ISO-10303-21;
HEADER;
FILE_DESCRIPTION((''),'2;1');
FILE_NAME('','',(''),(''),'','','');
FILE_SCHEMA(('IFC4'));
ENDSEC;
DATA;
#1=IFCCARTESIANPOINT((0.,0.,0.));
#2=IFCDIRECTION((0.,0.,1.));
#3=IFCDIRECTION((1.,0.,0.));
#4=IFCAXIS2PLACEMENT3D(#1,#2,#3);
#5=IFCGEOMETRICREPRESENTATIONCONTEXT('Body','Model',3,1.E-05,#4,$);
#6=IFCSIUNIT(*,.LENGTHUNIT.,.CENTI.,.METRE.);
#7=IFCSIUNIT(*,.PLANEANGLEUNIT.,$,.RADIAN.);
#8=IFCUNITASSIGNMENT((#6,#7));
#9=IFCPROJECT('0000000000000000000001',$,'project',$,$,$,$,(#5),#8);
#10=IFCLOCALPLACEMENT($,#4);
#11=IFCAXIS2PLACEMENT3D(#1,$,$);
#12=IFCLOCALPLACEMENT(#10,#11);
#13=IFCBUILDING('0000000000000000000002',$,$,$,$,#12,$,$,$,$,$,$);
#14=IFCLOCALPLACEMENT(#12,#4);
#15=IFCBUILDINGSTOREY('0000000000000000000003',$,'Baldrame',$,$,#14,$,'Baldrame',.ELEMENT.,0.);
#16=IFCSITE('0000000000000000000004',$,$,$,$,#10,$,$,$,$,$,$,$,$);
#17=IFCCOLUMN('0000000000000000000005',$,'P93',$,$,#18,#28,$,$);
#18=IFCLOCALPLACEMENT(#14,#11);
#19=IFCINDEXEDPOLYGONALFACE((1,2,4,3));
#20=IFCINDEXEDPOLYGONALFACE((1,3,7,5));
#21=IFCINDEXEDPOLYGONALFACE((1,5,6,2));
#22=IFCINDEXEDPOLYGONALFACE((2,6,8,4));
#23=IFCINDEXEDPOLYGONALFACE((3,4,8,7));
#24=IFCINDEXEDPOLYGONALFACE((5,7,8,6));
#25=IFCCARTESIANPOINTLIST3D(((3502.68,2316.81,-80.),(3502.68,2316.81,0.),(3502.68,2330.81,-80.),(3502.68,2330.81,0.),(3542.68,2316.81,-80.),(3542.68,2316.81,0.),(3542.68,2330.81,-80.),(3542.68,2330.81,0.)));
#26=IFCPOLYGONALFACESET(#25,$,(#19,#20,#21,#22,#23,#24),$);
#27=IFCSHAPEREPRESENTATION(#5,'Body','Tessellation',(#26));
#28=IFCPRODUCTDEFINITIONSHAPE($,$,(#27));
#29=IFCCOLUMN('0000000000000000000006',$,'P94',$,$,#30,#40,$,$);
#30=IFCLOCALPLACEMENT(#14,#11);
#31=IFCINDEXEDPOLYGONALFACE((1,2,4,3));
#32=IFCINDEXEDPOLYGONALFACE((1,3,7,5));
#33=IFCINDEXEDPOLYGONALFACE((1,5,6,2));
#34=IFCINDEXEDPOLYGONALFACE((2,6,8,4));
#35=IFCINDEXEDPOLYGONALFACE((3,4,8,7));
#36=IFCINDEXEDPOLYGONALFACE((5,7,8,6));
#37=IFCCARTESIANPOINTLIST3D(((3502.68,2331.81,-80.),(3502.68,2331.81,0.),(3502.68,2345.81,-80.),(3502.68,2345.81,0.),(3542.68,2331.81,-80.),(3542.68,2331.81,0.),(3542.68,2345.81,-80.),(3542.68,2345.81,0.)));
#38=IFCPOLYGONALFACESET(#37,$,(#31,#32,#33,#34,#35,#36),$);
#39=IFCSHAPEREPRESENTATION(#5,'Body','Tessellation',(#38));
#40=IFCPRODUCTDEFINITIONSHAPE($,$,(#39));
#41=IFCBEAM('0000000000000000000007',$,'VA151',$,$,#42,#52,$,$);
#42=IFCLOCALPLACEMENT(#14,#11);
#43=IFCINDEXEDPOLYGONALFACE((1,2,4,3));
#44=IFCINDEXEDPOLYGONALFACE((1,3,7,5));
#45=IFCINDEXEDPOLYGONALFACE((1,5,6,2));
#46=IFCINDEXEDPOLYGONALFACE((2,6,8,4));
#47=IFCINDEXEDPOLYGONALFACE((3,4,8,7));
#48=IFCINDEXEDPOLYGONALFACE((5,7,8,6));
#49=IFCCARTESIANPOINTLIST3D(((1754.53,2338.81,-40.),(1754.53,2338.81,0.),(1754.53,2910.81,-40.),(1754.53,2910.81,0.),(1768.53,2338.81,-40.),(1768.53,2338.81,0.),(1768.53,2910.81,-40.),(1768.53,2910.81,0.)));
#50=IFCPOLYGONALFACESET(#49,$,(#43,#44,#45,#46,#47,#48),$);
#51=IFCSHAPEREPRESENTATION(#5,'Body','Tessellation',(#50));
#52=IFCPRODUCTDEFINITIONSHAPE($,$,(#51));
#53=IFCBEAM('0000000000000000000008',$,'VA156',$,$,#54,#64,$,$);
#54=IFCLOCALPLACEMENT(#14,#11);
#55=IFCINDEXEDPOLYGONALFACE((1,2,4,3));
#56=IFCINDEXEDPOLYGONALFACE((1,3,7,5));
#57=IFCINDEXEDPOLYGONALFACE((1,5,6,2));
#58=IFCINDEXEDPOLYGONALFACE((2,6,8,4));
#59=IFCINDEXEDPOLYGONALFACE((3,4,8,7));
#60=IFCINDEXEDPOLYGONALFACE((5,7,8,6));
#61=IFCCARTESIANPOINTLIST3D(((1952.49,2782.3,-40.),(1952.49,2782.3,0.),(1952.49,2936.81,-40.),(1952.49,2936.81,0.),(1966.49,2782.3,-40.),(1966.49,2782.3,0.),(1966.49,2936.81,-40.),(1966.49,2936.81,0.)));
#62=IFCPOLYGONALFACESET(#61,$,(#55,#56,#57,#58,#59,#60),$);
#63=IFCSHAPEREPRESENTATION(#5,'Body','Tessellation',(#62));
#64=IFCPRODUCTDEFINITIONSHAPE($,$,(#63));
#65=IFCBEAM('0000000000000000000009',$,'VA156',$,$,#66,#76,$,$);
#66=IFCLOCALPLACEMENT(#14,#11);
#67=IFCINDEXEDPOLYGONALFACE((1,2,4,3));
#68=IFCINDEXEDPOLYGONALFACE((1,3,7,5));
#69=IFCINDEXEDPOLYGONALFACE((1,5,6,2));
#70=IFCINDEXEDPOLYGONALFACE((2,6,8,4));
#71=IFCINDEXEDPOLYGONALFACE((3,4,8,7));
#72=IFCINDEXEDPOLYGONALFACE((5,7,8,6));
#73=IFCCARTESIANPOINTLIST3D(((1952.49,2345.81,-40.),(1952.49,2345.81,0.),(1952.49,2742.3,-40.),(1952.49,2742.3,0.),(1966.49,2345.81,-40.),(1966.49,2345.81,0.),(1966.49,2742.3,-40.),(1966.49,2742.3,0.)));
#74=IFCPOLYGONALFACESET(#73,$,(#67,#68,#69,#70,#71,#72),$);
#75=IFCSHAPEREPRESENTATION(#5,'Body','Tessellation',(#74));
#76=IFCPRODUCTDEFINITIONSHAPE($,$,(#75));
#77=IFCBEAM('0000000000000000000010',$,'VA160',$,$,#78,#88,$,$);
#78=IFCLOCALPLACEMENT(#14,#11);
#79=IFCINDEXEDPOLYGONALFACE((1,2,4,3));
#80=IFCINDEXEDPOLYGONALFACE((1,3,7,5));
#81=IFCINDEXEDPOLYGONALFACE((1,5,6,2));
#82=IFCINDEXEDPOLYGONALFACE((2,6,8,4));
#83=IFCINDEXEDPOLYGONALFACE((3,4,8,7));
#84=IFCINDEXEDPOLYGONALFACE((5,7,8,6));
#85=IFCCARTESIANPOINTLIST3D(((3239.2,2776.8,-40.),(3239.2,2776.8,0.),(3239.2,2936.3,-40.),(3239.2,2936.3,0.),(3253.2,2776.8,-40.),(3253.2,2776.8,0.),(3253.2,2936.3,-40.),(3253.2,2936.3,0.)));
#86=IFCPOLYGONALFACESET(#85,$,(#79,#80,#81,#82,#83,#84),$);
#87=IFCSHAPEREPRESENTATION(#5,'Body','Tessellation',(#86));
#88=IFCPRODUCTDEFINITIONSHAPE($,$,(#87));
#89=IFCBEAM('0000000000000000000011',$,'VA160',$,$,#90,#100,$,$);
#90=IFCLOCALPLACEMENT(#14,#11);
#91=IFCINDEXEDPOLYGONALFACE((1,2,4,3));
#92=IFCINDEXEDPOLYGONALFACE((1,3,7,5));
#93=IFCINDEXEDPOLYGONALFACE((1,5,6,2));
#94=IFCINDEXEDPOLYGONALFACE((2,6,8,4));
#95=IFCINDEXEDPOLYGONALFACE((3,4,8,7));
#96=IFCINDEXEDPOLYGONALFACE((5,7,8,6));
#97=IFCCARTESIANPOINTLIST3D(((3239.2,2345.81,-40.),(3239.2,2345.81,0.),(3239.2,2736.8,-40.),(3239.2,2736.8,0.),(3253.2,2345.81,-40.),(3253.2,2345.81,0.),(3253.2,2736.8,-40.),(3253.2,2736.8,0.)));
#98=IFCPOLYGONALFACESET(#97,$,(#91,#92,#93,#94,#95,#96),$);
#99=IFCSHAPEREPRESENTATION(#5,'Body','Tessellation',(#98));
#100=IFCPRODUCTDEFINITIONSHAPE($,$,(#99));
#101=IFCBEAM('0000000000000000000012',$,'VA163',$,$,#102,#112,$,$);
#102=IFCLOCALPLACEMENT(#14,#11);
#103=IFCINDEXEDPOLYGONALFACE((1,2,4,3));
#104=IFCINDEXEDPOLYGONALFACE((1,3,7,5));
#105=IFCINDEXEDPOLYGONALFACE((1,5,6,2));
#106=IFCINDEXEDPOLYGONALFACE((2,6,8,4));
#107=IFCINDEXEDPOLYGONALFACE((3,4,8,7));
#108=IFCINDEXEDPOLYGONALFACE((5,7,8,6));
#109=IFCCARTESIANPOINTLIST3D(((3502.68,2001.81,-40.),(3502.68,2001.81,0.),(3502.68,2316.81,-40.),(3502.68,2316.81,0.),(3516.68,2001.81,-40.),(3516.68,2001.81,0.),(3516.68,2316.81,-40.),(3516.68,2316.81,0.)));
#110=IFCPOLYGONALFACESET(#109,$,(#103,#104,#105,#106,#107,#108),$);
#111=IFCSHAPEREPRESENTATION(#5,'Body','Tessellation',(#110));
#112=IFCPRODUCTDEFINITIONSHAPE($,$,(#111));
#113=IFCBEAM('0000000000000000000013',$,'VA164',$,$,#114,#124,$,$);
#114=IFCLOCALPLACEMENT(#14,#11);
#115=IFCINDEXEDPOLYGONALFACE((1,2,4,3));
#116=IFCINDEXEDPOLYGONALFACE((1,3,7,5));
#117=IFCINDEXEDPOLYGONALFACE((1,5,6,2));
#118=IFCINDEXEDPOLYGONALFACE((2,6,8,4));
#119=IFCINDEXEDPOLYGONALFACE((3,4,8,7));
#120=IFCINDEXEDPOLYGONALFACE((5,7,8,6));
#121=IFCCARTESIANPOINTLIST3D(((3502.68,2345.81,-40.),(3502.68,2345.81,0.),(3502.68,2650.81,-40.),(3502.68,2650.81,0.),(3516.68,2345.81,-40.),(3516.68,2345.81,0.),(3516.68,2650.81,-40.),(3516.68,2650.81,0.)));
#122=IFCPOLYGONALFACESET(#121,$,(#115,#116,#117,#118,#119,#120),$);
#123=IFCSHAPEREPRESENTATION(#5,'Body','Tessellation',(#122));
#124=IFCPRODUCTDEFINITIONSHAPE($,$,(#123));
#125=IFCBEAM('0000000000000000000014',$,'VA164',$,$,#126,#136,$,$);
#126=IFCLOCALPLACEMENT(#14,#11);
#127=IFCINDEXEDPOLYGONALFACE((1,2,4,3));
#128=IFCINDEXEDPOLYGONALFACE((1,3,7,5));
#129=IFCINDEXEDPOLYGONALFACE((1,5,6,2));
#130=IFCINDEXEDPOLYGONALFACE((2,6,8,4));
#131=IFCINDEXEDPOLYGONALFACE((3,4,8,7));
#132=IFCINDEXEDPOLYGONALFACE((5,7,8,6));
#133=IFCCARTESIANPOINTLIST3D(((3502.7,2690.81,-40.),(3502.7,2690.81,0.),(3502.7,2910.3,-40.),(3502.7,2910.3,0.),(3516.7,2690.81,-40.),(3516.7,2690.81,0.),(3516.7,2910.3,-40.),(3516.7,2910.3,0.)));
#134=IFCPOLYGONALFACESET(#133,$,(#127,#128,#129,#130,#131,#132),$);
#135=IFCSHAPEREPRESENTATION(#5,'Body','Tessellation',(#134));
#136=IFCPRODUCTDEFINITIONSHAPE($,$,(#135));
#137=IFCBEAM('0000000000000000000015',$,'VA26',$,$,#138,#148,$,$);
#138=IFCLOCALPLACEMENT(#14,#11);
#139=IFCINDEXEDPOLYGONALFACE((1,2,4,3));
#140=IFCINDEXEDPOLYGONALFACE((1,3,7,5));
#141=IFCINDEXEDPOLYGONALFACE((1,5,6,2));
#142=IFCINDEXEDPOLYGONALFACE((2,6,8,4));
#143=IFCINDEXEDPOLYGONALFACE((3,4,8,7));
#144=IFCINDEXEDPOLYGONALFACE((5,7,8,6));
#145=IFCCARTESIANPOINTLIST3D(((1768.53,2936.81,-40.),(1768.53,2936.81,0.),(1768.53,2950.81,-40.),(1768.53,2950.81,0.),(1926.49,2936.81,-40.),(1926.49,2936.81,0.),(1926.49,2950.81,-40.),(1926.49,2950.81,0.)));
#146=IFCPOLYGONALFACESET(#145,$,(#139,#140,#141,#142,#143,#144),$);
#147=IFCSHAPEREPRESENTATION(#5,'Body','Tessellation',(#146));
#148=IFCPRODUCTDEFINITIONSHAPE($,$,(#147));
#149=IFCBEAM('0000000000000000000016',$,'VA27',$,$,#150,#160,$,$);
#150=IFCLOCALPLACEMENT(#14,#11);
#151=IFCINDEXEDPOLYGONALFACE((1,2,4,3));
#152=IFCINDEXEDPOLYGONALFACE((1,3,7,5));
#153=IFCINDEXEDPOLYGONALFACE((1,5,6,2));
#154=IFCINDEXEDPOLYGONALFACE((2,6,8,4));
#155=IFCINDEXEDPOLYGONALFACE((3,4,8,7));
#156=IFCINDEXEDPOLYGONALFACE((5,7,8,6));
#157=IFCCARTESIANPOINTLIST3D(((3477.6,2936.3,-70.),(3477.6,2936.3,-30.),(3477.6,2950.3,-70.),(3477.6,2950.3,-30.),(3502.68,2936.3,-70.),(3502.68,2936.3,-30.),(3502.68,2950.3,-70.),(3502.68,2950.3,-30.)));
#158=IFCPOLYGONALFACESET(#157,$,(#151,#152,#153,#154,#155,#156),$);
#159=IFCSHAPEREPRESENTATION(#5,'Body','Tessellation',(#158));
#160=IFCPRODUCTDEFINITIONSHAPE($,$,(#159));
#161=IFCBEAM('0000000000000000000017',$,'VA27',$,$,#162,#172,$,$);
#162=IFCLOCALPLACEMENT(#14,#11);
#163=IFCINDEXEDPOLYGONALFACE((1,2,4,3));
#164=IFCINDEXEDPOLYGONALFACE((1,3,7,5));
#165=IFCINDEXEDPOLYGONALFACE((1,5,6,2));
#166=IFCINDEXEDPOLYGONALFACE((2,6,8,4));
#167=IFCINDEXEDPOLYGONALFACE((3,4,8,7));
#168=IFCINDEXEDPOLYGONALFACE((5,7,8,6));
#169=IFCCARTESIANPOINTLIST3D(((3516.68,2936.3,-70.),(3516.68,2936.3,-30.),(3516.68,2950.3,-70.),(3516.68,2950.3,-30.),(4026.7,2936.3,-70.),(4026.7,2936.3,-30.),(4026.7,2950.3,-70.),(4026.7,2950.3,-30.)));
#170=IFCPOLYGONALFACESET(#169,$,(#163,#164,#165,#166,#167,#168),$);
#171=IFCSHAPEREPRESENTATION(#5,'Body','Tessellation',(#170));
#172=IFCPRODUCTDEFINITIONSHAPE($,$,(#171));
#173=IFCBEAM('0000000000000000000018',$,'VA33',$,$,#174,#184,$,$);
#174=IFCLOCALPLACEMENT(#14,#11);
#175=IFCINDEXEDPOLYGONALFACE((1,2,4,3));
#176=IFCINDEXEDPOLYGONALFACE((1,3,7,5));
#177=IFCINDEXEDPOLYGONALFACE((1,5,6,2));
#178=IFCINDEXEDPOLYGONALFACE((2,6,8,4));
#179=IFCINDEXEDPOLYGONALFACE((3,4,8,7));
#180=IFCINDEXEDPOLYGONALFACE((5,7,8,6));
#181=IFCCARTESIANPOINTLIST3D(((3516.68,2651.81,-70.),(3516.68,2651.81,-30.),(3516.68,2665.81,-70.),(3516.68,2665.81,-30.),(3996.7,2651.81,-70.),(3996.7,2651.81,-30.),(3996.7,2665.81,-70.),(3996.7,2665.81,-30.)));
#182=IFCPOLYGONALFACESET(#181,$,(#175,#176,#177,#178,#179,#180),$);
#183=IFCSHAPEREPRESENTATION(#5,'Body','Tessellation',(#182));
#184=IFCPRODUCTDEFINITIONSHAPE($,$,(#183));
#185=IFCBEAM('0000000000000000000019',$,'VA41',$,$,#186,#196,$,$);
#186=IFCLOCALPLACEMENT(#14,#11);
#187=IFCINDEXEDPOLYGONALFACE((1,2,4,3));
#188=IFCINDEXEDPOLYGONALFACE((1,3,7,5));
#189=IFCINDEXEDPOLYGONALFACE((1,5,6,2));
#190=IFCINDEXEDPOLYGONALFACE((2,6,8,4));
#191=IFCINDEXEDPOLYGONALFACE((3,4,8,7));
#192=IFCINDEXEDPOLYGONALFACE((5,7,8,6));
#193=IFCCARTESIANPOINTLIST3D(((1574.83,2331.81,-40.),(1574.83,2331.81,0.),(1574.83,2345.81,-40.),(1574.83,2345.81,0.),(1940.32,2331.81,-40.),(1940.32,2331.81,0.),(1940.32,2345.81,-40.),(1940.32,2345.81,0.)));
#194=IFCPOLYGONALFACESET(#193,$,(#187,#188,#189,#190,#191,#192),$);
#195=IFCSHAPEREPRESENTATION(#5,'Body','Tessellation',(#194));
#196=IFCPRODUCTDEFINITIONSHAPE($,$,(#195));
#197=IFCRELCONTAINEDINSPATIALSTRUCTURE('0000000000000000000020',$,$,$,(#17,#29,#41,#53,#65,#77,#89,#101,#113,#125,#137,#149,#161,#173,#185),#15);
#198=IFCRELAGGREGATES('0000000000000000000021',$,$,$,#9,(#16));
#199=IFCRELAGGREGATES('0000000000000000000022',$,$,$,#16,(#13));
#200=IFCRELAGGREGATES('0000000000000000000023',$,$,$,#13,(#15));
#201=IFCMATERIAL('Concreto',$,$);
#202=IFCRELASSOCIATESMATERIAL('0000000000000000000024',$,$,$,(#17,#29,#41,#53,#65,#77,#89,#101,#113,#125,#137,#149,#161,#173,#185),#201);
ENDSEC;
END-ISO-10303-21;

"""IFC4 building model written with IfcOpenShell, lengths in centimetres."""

from ifc_helpers import new_model, si_unit, frame, origin, origin_with_axes, origin_2d_with_axis, place, context, project, spatial, rectangle, extrude, material, element, save


model = new_model("IFC4")

# Units and contexts
model_context = context("Model", 3, precision=1e-05, world=origin_with_axes(), identifier="Body")
ifc_project = project(units=[si_unit("LENGTHUNIT", "METRE", prefix="CENTI"), si_unit("PLANEANGLEUNIT", "RADIAN")], contexts=[model_context])

# Site, building, storey
site_placement = place(None, origin_with_axes())
site = spatial("IfcSite", under=ifc_project, at=site_placement)
building_placement = place(site_placement, origin())
building = spatial("IfcBuilding", under=site, at=building_placement)
storey_placement = place(building_placement, origin_with_axes())
storey = spatial("IfcBuildingStorey", under=building, at=storey_placement, Name="Baldrame", LongName="Baldrame", CompositionType="ELEMENT", Elevation=0.0)

# Shared definitions
ifc_material = material(Name="Concreto")

# Columns
for number, where, z_axis, x_axis, name in (
    (1, (3522.68, 2323.81, 0.0), (0.0, 0.0, 1.0), (1.0, 0.0, 0.0), "P93"),
    (2, (3522.68, 2338.81, 0.0), (0.0, 0.0, 1.0), (1.0, 0.0, 0.0), "P94"),
):
    element("IfcColumn", number, at=place(storey_placement, frame(where, z_axis=z_axis, x_axis=x_axis)), inside=storey, material=ifc_material, Name=name, context=model_context, shape_type="SolidModel", body=[
        extrude(rectangle(XDim=14.0, YDim=40.0, at=origin_2d_with_axis()), frame((0.0, 0.0, -80.0), z_axis=(0.0, 0.0, 1.0), x_axis=(0.0, -1.0, 0.0)), (0.0, 0.0, 1.0), 80.0),
    ])

# Beams
beam_1_placement = place(storey_placement, frame((1761.53, 2624.81, 0.0), z_axis=(0.0, 0.0, 1.0), x_axis=(1.0, 0.0, 0.0)))
element("IfcBeam", 3, at=beam_1_placement, inside=storey, material=ifc_material, Name="VA151", context=model_context, shape_type="SolidModel", body=[
    extrude(rectangle(XDim=14.0, YDim=40.0, at=origin_2d_with_axis()), frame((0.0, -286.0, -20.0), z_axis=(0.0, 1.0, 0.0), x_axis=(1.0, 0.0, 0.0)), (0.0, 0.0, 1.0), 572.0),
])
beam_2_placement = place(storey_placement, frame((1959.49, 2859.55, 0.0), z_axis=(0.0, 0.0, 1.0), x_axis=(1.0, 0.0, 0.0)))
element("IfcBeam", 4, at=beam_2_placement, inside=storey, material=ifc_material, Name="VA156", context=model_context, shape_type="SolidModel", body=[
    extrude(rectangle(XDim=14.0, YDim=40.0, at=origin_2d_with_axis()), frame((0.0, -77.25, -20.0), z_axis=(0.0, 1.0, 0.0), x_axis=(1.0, 0.0, 0.0)), (0.0, 0.0, 1.0), 154.51),
])
beam_3_placement = place(storey_placement, frame((1959.49, 2544.05, 0.0), z_axis=(0.0, 0.0, 1.0), x_axis=(1.0, 0.0, 0.0)))
element("IfcBeam", 5, at=beam_3_placement, inside=storey, material=ifc_material, Name="VA156", context=model_context, shape_type="SolidModel", body=[
    extrude(rectangle(XDim=14.0, YDim=40.0, at=origin_2d_with_axis()), frame((0.0, -198.25, -20.0), z_axis=(0.0, 1.0, 0.0), x_axis=(1.0, 0.0, 0.0)), (0.0, 0.0, 1.0), 396.49),
])
beam_4_placement = place(storey_placement, frame((3246.2, 2856.55, 0.0), z_axis=(0.0, 0.0, 1.0), x_axis=(1.0, 0.0, 0.0)))
element("IfcBeam", 6, at=beam_4_placement, inside=storey, material=ifc_material, Name="VA160", context=model_context, shape_type="SolidModel", body=[
    extrude(rectangle(XDim=14.0, YDim=40.0, at=origin_2d_with_axis()), frame((0.0, -79.75, -20.0), z_axis=(0.0, 1.0, 0.0), x_axis=(1.0, 0.0, 0.0)), (0.0, 0.0, 1.0), 159.5),
])
beam_5_placement = place(storey_placement, frame((3246.2, 2541.3, 0.0), z_axis=(0.0, 0.0, 1.0), x_axis=(1.0, 0.0, 0.0)))
element("IfcBeam", 7, at=beam_5_placement, inside=storey, material=ifc_material, Name="VA160", context=model_context, shape_type="SolidModel", body=[
    extrude(rectangle(XDim=14.0, YDim=40.0, at=origin_2d_with_axis()), frame((0.0, -195.5, -20.0), z_axis=(0.0, 1.0, 0.0), x_axis=(1.0, 0.0, 0.0)), (0.0, 0.0, 1.0), 390.99),
])
beam_6_placement = place(storey_placement, frame((3509.68, 2159.31, 0.0), z_axis=(0.0, 0.0, 1.0), x_axis=(1.0, 0.0, 0.0)))
element("IfcBeam", 8, at=beam_6_placement, inside=storey, material=ifc_material, Name="VA163", context=model_context, shape_type="SolidModel", body=[
    extrude(rectangle(XDim=14.0, YDim=40.0, at=origin_2d_with_axis()), frame((0.0, -157.5, -20.0), z_axis=(0.0, 1.0, 0.0), x_axis=(1.0, 0.0, 0.0)), (0.0, 0.0, 1.0), 315.0),
])
beam_7_placement = place(storey_placement, frame((3509.68, 2498.31, 0.0), z_axis=(0.0, 0.0, 1.0), x_axis=(1.0, 0.0, 0.0)))
element("IfcBeam", 9, at=beam_7_placement, inside=storey, material=ifc_material, Name="VA164", context=model_context, shape_type="SolidModel", body=[
    extrude(rectangle(XDim=14.0, YDim=40.0, at=origin_2d_with_axis()), frame((0.0, -152.5, -20.0), z_axis=(0.0, 1.0, 0.0), x_axis=(1.0, 0.0, 0.0)), (0.0, 0.0, 1.0), 305.0),
])
beam_8_placement = place(storey_placement, frame((3509.7, 2800.55, 0.0), z_axis=(0.0, 0.0, 1.0), x_axis=(1.0, 0.0, 0.0)))
element("IfcBeam", 10, at=beam_8_placement, inside=storey, material=ifc_material, Name="VA164", context=model_context, shape_type="SolidModel", body=[
    extrude(rectangle(XDim=14.0, YDim=40.0, at=origin_2d_with_axis()), frame((0.0, -109.75, -20.0), z_axis=(0.0, 1.0, 0.0), x_axis=(1.0, 0.0, 0.0)), (0.0, 0.0, 1.0), 219.49),
])
beam_9_placement = place(storey_placement, frame((1847.51, 2943.81, 0.0), z_axis=(0.0, 0.0, 1.0), x_axis=(1.0, 0.0, 0.0)))
element("IfcBeam", 11, at=beam_9_placement, inside=storey, material=ifc_material, Name="VA26", context=model_context, shape_type="SolidModel", body=[
    extrude(rectangle(XDim=14.0, YDim=40.0, at=origin_2d_with_axis()), frame((-78.98, 0.0, -20.0), z_axis=(1.0, 0.0, 0.0), x_axis=(0.0, 1.0, 0.0)), (0.0, 0.0, 1.0), 157.96),
])
beam_10_placement = place(storey_placement, frame((3490.14, 2943.3, -30.0), z_axis=(0.0, 0.0, 1.0), x_axis=(1.0, 0.0, 0.0)))
element("IfcBeam", 12, at=beam_10_placement, inside=storey, material=ifc_material, Name="VA27", context=model_context, shape_type="SolidModel", body=[
    extrude(rectangle(XDim=14.0, YDim=40.0, at=origin_2d_with_axis()), frame((-12.54, 0.0, -20.0), z_axis=(1.0, 0.0, 0.0), x_axis=(0.0, 1.0, 0.0)), (0.0, 0.0, 1.0), 25.08),
])
beam_11_placement = place(storey_placement, frame((3771.69, 2943.3, -30.0), z_axis=(0.0, 0.0, 1.0), x_axis=(1.0, 0.0, 0.0)))
element("IfcBeam", 13, at=beam_11_placement, inside=storey, material=ifc_material, Name="VA27", context=model_context, shape_type="SolidModel", body=[
    extrude(rectangle(XDim=14.0, YDim=40.0, at=origin_2d_with_axis()), frame((-255.01, 0.0, -20.0), z_axis=(1.0, 0.0, 0.0), x_axis=(0.0, 1.0, 0.0)), (0.0, 0.0, 1.0), 510.02),
])
beam_12_placement = place(storey_placement, frame((3756.69, 2658.81, -30.0), z_axis=(0.0, 0.0, 1.0), x_axis=(1.0, 0.0, 0.0)))
element("IfcBeam", 14, at=beam_12_placement, inside=storey, material=ifc_material, Name="VA33", context=model_context, shape_type="SolidModel", body=[
    extrude(rectangle(XDim=14.0, YDim=40.0, at=origin_2d_with_axis()), frame((-240.01, 0.0, -20.0), z_axis=(1.0, 0.0, 0.0), x_axis=(0.0, 1.0, 0.0)), (0.0, 0.0, 1.0), 480.02),
])
beam_13_placement = place(storey_placement, frame((1757.58, 2338.81, 0.0), z_axis=(0.0, 0.0, 1.0), x_axis=(1.0, 0.0, 0.0)))
element("IfcBeam", 15, at=beam_13_placement, inside=storey, material=ifc_material, Name="VA41", context=model_context, shape_type="SolidModel", body=[
    extrude(rectangle(XDim=14.0, YDim=40.0, at=origin_2d_with_axis()), frame((-182.75, 0.0, -20.0), z_axis=(1.0, 0.0, 0.0), x_axis=(0.0, 1.0, 0.0)), (0.0, 0.0, 1.0), 365.49),
])

save(model, "model.ifc")
